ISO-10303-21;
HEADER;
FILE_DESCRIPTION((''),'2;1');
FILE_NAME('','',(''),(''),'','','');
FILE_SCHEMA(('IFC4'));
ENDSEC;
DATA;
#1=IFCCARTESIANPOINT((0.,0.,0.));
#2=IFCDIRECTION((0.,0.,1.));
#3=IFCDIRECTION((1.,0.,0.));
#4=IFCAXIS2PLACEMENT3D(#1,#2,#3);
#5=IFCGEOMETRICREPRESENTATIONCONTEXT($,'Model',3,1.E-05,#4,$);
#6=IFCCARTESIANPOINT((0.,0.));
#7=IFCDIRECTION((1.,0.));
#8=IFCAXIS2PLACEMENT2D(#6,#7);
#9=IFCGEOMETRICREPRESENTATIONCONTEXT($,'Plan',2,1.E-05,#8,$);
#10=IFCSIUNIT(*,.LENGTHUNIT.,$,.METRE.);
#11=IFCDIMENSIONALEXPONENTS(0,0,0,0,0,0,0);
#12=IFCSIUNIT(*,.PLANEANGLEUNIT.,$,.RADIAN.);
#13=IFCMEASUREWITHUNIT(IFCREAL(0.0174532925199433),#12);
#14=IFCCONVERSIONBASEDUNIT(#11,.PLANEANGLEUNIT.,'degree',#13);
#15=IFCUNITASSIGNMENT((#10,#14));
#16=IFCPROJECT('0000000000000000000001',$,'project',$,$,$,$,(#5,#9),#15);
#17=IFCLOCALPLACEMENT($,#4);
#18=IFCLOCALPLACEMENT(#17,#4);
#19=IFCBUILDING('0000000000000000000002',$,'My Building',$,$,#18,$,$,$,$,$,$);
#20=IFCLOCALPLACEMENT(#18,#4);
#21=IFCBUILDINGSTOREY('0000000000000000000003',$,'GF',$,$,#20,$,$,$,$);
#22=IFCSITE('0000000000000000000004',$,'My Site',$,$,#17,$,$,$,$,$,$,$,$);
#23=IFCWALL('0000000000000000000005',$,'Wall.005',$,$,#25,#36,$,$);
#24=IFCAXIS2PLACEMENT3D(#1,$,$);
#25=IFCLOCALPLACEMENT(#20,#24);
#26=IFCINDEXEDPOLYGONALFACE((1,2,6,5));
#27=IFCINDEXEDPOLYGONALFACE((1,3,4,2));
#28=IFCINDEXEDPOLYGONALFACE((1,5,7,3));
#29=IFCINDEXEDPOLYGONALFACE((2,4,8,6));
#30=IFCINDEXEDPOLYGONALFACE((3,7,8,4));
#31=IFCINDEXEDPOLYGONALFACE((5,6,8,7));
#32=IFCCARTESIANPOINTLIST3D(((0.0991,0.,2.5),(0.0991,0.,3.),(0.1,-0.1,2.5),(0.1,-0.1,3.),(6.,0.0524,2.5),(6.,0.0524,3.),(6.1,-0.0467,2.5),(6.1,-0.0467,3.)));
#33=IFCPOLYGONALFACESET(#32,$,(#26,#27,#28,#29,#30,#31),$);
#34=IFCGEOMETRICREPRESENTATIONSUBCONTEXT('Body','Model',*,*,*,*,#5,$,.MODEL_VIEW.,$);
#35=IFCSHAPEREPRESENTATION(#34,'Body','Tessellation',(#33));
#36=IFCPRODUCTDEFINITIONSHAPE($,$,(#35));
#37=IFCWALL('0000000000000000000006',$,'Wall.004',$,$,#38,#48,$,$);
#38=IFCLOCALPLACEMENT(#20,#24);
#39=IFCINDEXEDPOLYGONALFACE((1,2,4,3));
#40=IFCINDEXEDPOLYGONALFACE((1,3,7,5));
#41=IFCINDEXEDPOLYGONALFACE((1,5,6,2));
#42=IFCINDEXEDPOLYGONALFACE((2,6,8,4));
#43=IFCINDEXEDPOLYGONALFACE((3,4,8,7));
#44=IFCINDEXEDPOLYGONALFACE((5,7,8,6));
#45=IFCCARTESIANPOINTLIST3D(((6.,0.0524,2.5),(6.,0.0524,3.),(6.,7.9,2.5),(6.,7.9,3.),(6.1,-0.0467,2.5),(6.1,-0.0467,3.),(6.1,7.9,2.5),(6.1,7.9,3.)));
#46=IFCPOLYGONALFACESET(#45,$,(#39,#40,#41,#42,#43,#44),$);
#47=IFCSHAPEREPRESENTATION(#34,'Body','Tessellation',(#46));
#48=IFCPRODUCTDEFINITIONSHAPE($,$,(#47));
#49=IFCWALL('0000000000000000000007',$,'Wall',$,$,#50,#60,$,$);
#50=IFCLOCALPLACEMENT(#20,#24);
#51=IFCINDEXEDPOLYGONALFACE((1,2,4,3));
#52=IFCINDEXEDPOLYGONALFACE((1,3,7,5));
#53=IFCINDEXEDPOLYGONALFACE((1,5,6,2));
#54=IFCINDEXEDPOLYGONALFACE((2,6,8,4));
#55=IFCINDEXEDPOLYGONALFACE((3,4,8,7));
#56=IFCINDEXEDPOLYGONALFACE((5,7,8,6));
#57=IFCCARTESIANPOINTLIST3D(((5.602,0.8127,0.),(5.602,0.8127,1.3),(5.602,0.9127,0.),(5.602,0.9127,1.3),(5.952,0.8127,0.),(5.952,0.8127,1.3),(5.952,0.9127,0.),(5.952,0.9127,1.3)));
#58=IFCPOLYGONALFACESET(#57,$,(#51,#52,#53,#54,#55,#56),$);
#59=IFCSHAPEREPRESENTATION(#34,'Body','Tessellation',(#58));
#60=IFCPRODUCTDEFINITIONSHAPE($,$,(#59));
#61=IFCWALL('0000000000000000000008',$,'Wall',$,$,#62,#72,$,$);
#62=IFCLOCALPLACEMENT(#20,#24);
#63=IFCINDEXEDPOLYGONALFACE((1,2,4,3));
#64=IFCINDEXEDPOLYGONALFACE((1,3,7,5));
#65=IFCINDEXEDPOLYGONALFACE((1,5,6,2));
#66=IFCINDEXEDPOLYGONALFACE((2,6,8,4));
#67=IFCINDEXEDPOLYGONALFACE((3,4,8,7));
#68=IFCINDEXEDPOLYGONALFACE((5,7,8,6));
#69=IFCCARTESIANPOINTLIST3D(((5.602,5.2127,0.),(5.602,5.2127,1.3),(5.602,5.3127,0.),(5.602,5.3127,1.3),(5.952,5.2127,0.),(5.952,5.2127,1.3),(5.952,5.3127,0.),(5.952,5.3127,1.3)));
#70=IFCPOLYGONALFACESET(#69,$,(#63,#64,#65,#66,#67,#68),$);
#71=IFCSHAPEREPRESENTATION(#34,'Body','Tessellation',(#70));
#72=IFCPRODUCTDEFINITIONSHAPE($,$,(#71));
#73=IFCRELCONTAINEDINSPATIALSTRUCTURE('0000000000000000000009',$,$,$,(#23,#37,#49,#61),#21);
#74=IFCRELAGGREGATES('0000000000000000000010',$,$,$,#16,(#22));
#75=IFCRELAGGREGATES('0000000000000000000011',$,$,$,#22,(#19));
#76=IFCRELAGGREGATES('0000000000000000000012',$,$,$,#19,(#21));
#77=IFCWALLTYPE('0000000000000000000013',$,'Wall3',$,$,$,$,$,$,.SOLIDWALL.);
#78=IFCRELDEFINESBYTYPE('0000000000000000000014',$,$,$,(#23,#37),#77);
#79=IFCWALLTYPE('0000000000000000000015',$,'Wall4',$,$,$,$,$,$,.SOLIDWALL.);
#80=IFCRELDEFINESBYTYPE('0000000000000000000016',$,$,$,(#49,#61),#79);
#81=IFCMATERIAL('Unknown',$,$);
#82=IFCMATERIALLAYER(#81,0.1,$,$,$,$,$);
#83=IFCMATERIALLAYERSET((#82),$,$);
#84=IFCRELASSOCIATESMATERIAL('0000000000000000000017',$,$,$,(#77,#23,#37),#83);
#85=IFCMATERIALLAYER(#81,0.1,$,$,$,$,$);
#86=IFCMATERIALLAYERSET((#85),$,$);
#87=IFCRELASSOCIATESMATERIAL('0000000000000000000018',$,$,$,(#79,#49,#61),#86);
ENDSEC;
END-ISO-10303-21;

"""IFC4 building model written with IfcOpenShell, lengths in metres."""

from ifc_helpers import new_model, entity, si_unit, converted_unit, frame, origin_with_axes, origin_2d_with_axis, place, context, subcontext, project, spatial, line, indexed_curve, outline, extrude, material, layer, layer_set, layer_usage, type_object, element, save


model = new_model("IFC4")

# Units and contexts
model_context = context("Model", 3, precision=1e-05, world=origin_with_axes())
plan_context = context("Plan", 2, precision=1e-05, world=origin_2d_with_axis())
body_context_1 = subcontext(model_context, "Body", "Model", "MODEL_VIEW")
ifc_project = project(units=[si_unit("LENGTHUNIT", "METRE"), converted_unit("PLANEANGLEUNIT", "degree", entity("IfcReal", 0.0174532925199433), si_unit("PLANEANGLEUNIT", "RADIAN"), dimensions=[0, 0, 0, 0, 0, 0, 0])], contexts=[model_context, plan_context])

# Site, building, storey
site_placement = place(None, origin_with_axes())
site = spatial("IfcSite", under=ifc_project, at=site_placement, Name="My Site")
building_placement = place(site_placement, origin_with_axes())
building = spatial("IfcBuilding", under=site, at=building_placement, Name="My Building")
storey_placement = place(building_placement, origin_with_axes())
storey = spatial("IfcBuildingStorey", under=building, at=storey_placement, Name="GF")

# Shared definitions
ifc_material = material(Name="Unknown")

# Walls
ifc_layer_1 = layer(ifc_material, 0.1)
ifc_layer_set_1 = layer_set([ifc_layer_1])
ifc_layer_usage_1 = layer_usage(ifc_layer_set_1, "AXIS2", "POSITIVE", 0.0)
wall_type_1 = type_object("IfcWallType", Name="Wall3", PredefinedType="SOLIDWALL", material=ifc_layer_set_1)
wall_1_placement = place(storey_placement, frame((0.1, -0.1, 2.5), z_axis=(0.0, 0.0, 1.0), x_axis=(0.999961, 0.008884, 0.0)))
element("IfcWall", 1, at=wall_1_placement, inside=storey, type_object=wall_type_1, material=ifc_layer_usage_1, Name="Wall.005", context=body_context_1, shape_type="SweptSolid", body=[
    extrude(outline(indexed_curve([(0.0, 0.0), (0.0, 0.1), (5.9011, 0.1), (6.0002, 0.0)], segments=[line(1, 2, 3, 4, 1)])), origin_with_axes(), (0.0, 0.0, 1.0), 0.5),
])
ifc_layer_usage_2 = layer_usage(ifc_layer_set_1, "AXIS2", "POSITIVE", 0.0)
wall_2_placement = place(storey_placement, frame((6.1, -0.0467, 2.5), z_axis=(0.0, 0.0, 1.0), x_axis=(0.0, 1.0, 0.0)))
element("IfcWall", 2, at=wall_2_placement, inside=storey, type_object=wall_type_1, material=ifc_layer_usage_2, Name="Wall.004", context=body_context_1, shape_type="SweptSolid", body=[
    extrude(outline(indexed_curve([(0.0, 0.0), (0.0991, 0.1), (7.9467, 0.1), (7.9467, 0.0)], segments=[line(1, 2, 3, 4, 1)])), origin_with_axes(), (0.0, 0.0, 1.0), 0.5),
])
ifc_layer_2 = layer(ifc_material, 0.1)
ifc_layer_set_2 = layer_set([ifc_layer_2])
ifc_layer_usage_3 = layer_usage(ifc_layer_set_2, "AXIS2", "POSITIVE", 0.0)
wall_type_2 = type_object("IfcWallType", Name="Wall4", PredefinedType="SOLIDWALL", material=ifc_layer_set_2)
wall_3_placement = place(storey_placement, frame((5.602, 0.8127, 0.0), z_axis=(0.0, 0.0, 1.0), x_axis=(1.0, 0.0, 0.0)))
element("IfcWall", 3, at=wall_3_placement, inside=storey, type_object=wall_type_2, material=ifc_layer_usage_3, Name="Wall", context=body_context_1, shape_type="SweptSolid", body=[
    extrude(outline(indexed_curve([(0.0, 0.0), (0.0, 0.1), (0.35, 0.1), (0.35, 0.0)], segments=[line(1, 2, 3, 4, 1)])), origin_with_axes(), (0.0, 0.0, 1.0), 1.3),
])
ifc_layer_usage_4 = layer_usage(ifc_layer_set_2, "AXIS2", "POSITIVE", 0.0)
wall_4_placement = place(storey_placement, frame((5.602, 5.2127, 0.0), z_axis=(0.0, 0.0, 1.0), x_axis=(1.0, 0.0, 0.0)))
element("IfcWall", 4, at=wall_4_placement, inside=storey, type_object=wall_type_2, material=ifc_layer_usage_4, Name="Wall", context=body_context_1, shape_type="SweptSolid", body=[
    extrude(outline(indexed_curve([(0.0, 0.0), (0.0, 0.1), (0.35, 0.1), (0.35, 0.0)], segments=[line(1, 2, 3, 4, 1)])), origin_with_axes(), (0.0, 0.0, 1.0), 1.3),
])

save(model, "model.ifc")
